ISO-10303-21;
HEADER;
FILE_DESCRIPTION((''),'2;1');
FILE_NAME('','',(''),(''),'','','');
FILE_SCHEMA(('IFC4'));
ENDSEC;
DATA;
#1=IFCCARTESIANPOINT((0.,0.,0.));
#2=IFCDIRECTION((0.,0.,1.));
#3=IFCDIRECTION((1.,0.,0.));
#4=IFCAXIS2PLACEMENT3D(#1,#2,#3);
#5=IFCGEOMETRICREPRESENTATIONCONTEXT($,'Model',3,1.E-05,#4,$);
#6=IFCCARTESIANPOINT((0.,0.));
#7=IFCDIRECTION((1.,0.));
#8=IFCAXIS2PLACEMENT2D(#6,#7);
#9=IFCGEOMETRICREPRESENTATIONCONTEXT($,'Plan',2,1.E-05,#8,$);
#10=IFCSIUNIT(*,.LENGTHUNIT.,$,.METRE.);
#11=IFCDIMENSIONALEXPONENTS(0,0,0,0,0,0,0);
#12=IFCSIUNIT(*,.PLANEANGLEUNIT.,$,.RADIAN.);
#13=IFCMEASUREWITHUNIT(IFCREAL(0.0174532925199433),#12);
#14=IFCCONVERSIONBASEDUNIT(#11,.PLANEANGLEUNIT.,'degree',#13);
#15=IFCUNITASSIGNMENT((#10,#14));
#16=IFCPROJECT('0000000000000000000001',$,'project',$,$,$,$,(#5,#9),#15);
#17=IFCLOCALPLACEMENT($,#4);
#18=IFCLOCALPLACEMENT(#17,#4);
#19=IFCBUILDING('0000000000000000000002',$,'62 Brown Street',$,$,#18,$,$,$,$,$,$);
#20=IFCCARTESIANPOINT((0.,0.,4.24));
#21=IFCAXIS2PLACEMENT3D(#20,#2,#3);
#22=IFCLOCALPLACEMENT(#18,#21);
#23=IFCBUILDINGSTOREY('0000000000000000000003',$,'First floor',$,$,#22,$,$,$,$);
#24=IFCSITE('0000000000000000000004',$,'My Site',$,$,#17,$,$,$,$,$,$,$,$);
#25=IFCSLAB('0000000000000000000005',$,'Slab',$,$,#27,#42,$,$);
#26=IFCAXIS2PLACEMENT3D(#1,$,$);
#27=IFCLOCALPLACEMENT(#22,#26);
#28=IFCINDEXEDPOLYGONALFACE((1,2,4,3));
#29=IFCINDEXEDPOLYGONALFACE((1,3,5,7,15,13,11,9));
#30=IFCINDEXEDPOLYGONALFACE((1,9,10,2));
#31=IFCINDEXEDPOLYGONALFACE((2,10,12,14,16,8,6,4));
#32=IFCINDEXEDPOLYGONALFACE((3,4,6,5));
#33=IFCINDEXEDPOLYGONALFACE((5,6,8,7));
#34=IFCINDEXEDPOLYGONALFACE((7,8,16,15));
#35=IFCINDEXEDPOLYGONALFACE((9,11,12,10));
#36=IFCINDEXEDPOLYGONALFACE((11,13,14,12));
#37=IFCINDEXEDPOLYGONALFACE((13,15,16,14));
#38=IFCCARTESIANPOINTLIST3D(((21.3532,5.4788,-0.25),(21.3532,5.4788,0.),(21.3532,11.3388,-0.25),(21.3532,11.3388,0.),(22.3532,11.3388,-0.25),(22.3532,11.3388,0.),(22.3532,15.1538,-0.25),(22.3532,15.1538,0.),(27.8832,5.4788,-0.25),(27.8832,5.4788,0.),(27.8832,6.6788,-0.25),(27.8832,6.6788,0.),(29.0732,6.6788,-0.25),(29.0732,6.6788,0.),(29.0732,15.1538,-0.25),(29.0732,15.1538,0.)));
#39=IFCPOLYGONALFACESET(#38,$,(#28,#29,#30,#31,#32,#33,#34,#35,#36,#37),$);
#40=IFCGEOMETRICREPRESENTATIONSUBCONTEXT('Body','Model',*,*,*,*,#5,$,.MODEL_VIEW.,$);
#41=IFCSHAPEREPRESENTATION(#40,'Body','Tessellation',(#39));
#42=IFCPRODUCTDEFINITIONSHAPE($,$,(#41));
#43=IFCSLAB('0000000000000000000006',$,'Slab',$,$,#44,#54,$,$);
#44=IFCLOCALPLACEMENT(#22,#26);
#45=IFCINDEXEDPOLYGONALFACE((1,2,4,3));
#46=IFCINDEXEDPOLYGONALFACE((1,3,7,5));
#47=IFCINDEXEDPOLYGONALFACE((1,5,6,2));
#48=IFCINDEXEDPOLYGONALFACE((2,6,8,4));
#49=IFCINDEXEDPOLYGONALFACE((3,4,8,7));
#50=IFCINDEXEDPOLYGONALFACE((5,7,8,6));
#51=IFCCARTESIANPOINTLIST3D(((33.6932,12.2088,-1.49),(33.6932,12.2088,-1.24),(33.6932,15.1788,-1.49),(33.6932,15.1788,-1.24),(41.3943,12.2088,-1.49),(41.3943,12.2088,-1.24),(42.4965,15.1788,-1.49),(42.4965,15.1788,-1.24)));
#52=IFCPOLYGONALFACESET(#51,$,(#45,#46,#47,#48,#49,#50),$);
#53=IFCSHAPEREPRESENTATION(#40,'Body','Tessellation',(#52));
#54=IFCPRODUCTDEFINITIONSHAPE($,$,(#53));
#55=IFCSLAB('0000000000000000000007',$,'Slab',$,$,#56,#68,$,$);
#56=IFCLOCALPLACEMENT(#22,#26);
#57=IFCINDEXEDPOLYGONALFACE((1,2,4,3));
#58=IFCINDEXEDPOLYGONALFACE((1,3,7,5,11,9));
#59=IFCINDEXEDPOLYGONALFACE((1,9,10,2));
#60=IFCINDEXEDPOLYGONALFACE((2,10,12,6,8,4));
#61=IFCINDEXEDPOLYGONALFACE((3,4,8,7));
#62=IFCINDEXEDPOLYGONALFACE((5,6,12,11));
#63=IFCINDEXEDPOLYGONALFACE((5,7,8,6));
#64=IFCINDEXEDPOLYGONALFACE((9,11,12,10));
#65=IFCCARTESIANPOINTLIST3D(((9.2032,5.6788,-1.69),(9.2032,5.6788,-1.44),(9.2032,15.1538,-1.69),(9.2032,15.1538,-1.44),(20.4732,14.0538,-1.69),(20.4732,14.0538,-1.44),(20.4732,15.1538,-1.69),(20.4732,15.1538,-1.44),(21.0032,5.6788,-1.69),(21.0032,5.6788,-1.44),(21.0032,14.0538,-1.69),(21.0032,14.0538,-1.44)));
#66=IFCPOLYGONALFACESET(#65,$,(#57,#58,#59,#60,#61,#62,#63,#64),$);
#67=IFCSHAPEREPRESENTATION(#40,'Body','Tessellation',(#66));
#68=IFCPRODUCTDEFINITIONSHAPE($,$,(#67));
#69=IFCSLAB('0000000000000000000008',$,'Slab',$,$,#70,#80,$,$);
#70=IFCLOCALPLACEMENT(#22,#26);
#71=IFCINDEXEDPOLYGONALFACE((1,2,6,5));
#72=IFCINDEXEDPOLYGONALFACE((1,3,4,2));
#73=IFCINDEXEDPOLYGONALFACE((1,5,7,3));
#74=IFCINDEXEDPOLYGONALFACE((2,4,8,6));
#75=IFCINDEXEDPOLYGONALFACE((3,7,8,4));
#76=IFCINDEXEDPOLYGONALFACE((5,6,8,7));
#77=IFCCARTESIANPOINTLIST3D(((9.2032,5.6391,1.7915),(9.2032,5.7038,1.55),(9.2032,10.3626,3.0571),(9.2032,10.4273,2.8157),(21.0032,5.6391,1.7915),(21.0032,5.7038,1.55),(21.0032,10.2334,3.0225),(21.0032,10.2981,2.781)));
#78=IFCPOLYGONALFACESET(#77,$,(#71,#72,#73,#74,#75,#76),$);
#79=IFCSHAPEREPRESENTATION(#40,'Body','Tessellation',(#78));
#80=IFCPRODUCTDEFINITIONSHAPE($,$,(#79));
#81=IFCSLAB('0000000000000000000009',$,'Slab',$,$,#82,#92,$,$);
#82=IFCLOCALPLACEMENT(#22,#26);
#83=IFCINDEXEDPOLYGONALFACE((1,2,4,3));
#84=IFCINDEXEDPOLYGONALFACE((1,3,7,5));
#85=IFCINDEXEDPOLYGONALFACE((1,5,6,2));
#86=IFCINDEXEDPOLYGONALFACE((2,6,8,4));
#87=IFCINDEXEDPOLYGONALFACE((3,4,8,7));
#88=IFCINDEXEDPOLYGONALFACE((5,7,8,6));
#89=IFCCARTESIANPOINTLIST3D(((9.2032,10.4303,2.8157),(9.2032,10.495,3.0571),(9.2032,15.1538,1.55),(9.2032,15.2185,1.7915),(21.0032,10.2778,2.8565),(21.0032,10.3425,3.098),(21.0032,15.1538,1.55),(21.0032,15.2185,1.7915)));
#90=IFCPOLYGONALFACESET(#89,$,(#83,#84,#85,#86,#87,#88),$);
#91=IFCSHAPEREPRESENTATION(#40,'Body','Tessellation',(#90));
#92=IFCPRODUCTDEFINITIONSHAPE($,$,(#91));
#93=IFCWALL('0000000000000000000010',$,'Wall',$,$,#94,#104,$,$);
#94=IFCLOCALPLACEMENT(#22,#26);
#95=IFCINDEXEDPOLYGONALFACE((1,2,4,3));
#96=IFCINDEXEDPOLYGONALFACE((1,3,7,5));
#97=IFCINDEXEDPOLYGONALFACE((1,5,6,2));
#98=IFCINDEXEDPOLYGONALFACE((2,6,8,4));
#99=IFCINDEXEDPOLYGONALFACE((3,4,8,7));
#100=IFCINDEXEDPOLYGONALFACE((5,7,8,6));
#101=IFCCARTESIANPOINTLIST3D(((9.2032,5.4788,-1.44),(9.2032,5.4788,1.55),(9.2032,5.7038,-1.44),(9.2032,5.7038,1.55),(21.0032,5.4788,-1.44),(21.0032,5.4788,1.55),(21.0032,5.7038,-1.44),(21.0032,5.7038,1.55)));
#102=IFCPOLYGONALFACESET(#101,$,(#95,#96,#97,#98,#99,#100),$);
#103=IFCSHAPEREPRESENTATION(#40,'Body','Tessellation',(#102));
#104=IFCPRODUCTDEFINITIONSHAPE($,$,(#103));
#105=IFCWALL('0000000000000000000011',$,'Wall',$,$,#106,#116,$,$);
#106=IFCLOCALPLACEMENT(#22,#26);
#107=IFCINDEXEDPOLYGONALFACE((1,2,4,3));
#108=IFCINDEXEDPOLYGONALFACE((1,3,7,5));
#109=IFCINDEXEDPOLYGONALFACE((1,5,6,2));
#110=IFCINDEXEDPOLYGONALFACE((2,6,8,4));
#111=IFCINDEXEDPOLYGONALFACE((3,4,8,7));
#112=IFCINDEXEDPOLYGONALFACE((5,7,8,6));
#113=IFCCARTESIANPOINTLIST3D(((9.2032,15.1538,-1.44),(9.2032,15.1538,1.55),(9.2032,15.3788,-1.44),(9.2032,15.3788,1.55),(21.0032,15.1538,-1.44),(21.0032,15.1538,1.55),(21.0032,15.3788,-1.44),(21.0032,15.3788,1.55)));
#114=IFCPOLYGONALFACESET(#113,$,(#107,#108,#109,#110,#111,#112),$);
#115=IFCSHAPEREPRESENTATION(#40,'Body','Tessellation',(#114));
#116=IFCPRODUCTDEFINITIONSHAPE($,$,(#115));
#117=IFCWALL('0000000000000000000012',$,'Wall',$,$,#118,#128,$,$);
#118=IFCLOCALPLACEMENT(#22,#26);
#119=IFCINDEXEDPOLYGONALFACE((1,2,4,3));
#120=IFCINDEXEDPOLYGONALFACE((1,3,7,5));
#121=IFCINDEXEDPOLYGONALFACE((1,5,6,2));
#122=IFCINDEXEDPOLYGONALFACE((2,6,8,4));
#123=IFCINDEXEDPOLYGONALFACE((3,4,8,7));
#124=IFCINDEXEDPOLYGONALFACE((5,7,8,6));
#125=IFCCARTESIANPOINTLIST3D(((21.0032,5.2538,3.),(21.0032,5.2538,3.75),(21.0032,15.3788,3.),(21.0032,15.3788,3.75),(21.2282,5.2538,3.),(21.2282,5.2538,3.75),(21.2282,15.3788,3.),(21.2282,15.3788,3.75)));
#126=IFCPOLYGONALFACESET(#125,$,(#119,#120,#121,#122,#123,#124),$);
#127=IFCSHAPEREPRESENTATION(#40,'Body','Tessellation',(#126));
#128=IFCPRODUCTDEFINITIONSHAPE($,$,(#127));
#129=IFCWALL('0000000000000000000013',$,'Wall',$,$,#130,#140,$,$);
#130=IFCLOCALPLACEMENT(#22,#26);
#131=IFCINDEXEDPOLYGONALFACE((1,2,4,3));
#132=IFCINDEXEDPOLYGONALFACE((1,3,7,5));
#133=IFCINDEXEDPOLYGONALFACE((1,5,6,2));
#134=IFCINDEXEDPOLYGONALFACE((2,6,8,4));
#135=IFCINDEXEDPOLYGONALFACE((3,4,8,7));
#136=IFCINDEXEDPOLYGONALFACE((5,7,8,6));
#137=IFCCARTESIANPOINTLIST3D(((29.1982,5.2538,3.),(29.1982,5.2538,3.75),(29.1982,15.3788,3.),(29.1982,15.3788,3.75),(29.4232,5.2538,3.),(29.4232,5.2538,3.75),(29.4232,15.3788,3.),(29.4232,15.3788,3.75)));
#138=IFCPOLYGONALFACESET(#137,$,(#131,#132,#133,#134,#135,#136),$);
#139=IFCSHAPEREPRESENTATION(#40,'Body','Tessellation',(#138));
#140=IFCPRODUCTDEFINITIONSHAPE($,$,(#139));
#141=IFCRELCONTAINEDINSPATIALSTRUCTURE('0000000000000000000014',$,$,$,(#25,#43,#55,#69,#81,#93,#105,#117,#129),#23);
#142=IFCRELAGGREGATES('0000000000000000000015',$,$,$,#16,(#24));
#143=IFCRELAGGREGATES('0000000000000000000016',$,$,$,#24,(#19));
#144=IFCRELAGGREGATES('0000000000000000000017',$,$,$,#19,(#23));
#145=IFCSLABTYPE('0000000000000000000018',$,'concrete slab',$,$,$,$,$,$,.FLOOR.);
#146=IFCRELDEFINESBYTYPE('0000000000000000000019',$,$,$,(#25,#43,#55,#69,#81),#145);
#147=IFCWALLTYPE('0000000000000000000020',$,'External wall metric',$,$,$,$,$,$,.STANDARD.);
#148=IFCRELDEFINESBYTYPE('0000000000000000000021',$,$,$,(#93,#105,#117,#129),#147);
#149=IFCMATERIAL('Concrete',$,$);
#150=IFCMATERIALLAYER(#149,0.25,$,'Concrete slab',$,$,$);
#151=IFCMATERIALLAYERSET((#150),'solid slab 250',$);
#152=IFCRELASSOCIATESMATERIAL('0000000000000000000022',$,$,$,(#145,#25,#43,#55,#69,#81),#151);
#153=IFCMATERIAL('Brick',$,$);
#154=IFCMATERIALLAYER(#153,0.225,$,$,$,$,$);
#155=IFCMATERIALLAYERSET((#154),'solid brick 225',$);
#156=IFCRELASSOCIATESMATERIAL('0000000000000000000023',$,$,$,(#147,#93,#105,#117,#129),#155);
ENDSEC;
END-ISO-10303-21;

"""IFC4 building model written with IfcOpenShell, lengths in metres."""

from ifc_helpers import new_model, entity, si_unit, converted_unit, frame, origin_with_axes, origin_2d_with_axis, place, context, subcontext, project, spatial, line, indexed_curve, outline, extrude, material, layer, layer_set, layer_usage, type_object, element, save


model = new_model("IFC4")

# Units and contexts
model_context = context("Model", 3, precision=1e-05, world=origin_with_axes())
plan_context = context("Plan", 2, precision=1e-05, world=origin_2d_with_axis())
body_context_1 = subcontext(model_context, "Body", "Model", "MODEL_VIEW")
ifc_project = project(units=[si_unit("LENGTHUNIT", "METRE"), converted_unit("PLANEANGLEUNIT", "degree", entity("IfcReal", 0.0174532925199433), si_unit("PLANEANGLEUNIT", "RADIAN"), dimensions=[0, 0, 0, 0, 0, 0, 0])], contexts=[model_context, plan_context])

# Site, building, storey
site_placement = place(None, origin_with_axes())
site = spatial("IfcSite", under=ifc_project, at=site_placement, Name="My Site")
building_placement = place(site_placement, origin_with_axes())
building = spatial("IfcBuilding", under=site, at=building_placement, Name="62 Brown Street")
storey_placement = place(building_placement, frame((0.0, 0.0, 4.24), z_axis=(0.0, 0.0, 1.0), x_axis=(1.0, 0.0, 0.0)))
storey = spatial("IfcBuildingStorey", under=building, at=storey_placement, Name="First floor")

# Slabs
ifc_material_1 = material(Name="Concrete")
ifc_layer_1 = layer(ifc_material_1, 0.25, Name="Concrete slab")
ifc_layer_set_1 = layer_set([ifc_layer_1], Name="solid slab 250")
ifc_layer_usage_1 = layer_usage(ifc_layer_set_1, "AXIS3", "POSITIVE", 0.0)
slab_type = type_object("IfcSlabType", Name="concrete slab", PredefinedType="FLOOR", material=ifc_layer_set_1)
slab_1_placement = place(storey_placement, frame((21.3532, 5.4788, -0.25), z_axis=(0.0, 0.0, 1.0), x_axis=(1.0, 0.0, 0.0)))
element("IfcSlab", 1, at=slab_1_placement, inside=storey, type_object=slab_type, material=ifc_layer_usage_1, Name="Slab", context=body_context_1, shape_type="SweptSolid", body=[
    extrude(outline(indexed_curve([(0.0, 5.86), (0.0, 0.0), (6.53, 0.0), (6.53, 1.2), (7.72, 1.2), (7.72, 9.675), (1.0, 9.675), (1.0, 5.86)], segments=[line(3, 2), line(2, 1), line(1, 8), line(8, 7), line(7, 6), line(6, 5), line(5, 4), line(4, 3)], self_intersect=False)), None, (0.0, 0.0, 1.0), 0.25),
])
ifc_layer_usage_2 = layer_usage(ifc_layer_set_1, "AXIS3", "POSITIVE", 0.0)
slab_2_placement = place(storey_placement, frame((33.6932, 12.2088, -1.49), z_axis=(0.0, 0.0, 1.0), x_axis=(1.0, 0.0, 0.0)))
element("IfcSlab", 2, at=slab_2_placement, inside=storey, type_object=slab_type, material=ifc_layer_usage_2, Name="Slab", context=body_context_1, shape_type="SweptSolid", body=[
    extrude(outline(indexed_curve([(8.8033, 2.97), (7.7011, 0.0), (0.0, 0.0), (0.0, 2.97)], segments=[line(4, 1), line(1, 2), line(2, 3), line(3, 4)], self_intersect=False)), None, (0.0, 0.0, 1.0), 0.25),
])
ifc_layer_usage_3 = layer_usage(ifc_layer_set_1, "AXIS3", "POSITIVE", 0.0)
slab_3_placement = place(storey_placement, frame((9.2032, 5.6788, -1.69), z_axis=(0.0, 0.0, 1.0), x_axis=(1.0, 0.0, 0.0)))
element("IfcSlab", 3, at=slab_3_placement, inside=storey, type_object=slab_type, material=ifc_layer_usage_3, Name="Slab", context=body_context_1, shape_type="SweptSolid", body=[
    extrude(outline(indexed_curve([(11.27, 9.475), (11.8, 0.0), (0.0, 0.0), (0.0, 9.475), (11.8, 8.375), (11.27, 8.375)], segments=[line(6, 1), line(1, 4), line(4, 3), line(3, 2), line(2, 5), line(5, 6)], self_intersect=False)), None, (0.0, 0.0, 1.0), 0.25),
])
ifc_layer_usage_4 = layer_usage(ifc_layer_set_1, "AXIS3", "POSITIVE", 0.0)
slab_4_placement = place(storey_placement, frame((9.2032, 5.7038, 1.55), z_axis=(0.0, -0.258819, 0.965926), x_axis=(1.0, 0.0, 0.0)))
element("IfcSlab", 4, at=slab_4_placement, inside=storey, type_object=slab_type, material=ifc_layer_usage_4, Name="Slab", context=body_context_1, shape_type="SweptSolid", body=[
    extrude(outline(indexed_curve([(0.0, 4.8901), (0.0, 0.0), (11.8, 0.0), (11.8, 4.7563)], segments=[line(3, 2), line(2, 1), line(1, 4), line(4, 3)], self_intersect=False)), None, (0.0, 0.0, 1.0), 0.25),
])
ifc_layer_usage_5 = layer_usage(ifc_layer_set_1, "AXIS3", "POSITIVE", 0.0)
slab_5_placement = place(storey_placement, frame((21.0032, 15.1538, 1.55), z_axis=(0.0, 0.258819, 0.965926), x_axis=(-1.0, 0.0, 0.0)))
element("IfcSlab", 5, at=slab_5_placement, inside=storey, type_object=slab_type, material=ifc_layer_usage_5, Name="Slab", context=body_context_1, shape_type="SweptSolid", body=[
    extrude(outline(indexed_curve([(0.0, 0.0), (11.8, 0.0), (11.8, 4.8901), (0.0, 5.048)], segments=[line(4, 1), line(1, 2), line(2, 3), line(3, 4)], self_intersect=False)), None, (0.0, 0.0, 1.0), 0.25),
])

# Walls
ifc_material_2 = material(Name="Brick")
ifc_layer_2 = layer(ifc_material_2, 0.225)
ifc_layer_set_2 = layer_set([ifc_layer_2], Name="solid brick 225")
ifc_layer_usage_6 = layer_usage(ifc_layer_set_2, "AXIS2", "POSITIVE", 0.0)
wall_type_1 = type_object("IfcWallType", Name="External wall metric", PredefinedType="STANDARD", material=ifc_layer_set_2)
wall_1_placement = place(storey_placement, frame((9.2032, 5.4788, -1.44), z_axis=(0.0, 0.0, 1.0), x_axis=(1.0, 0.0, 0.0)))
element("IfcWall", 6, at=wall_1_placement, inside=storey, type_object=wall_type_1, material=ifc_layer_usage_6, Name="Wall", context=body_context_1, shape_type="SweptSolid", body=[
    extrude(outline(indexed_curve([(0.0, 0.0), (0.0, 0.225), (11.8, 0.225), (11.8, 0.0), (0.0, 0.0)], self_intersect=False)), origin_with_axes(), (0.0, 0.0, 1.0), 2.99),
])
ifc_layer_usage_7 = layer_usage(ifc_layer_set_2, "AXIS2", "POSITIVE", 0.0)
wall_2_placement = place(storey_placement, frame((21.0032, 15.3788, -1.44), z_axis=(0.0, 0.0, 1.0), x_axis=(-1.0, 0.0, 0.0)))
element("IfcWall", 7, at=wall_2_placement, inside=storey, type_object=wall_type_1, material=ifc_layer_usage_7, Name="Wall", context=body_context_1, shape_type="SweptSolid", body=[
    extrude(outline(indexed_curve([(0.0, 0.0), (0.0, 0.225), (11.8, 0.225), (11.8, 0.0), (0.0, 0.0)], self_intersect=False)), origin_with_axes(), (0.0, 0.0, 1.0), 2.99),
])
ifc_layer_usage_8 = layer_usage(ifc_layer_set_2, "AXIS2", "POSITIVE", 0.0)
wall_3_placement = place(storey_placement, frame((21.0032, 15.3788, 3.0), z_axis=(0.0, 0.0, 1.0), x_axis=(0.0, -1.0, 0.0)))
element("IfcWall", 8, at=wall_3_placement, inside=storey, type_object=wall_type_1, material=ifc_layer_usage_8, Name="Wall", context=body_context_1, shape_type="SweptSolid", body=[
    extrude(outline(indexed_curve([(0.0, 0.0), (0.0, 0.225), (10.125, 0.225), (10.125, 0.0), (0.0, 0.0)], self_intersect=False)), origin_with_axes(), (0.0, 0.0, 1.0), 0.75),
])
ifc_layer_usage_9 = layer_usage(ifc_layer_set_2, "AXIS2", "POSITIVE", 0.0)
wall_4_placement = place(storey_placement, frame((29.4232, 5.2538, 3.0), z_axis=(0.0, 0.0, 1.0), x_axis=(0.0, 1.0, 0.0)))
element("IfcWall", 9, at=wall_4_placement, inside=storey, type_object=wall_type_1, material=ifc_layer_usage_9, Name="Wall", context=body_context_1, shape_type="SweptSolid", body=[
    extrude(outline(indexed_curve([(0.0, 0.0), (0.0, 0.225), (10.125, 0.225), (10.125, 0.0), (0.0, 0.0)], self_intersect=False)), origin_with_axes(), (0.0, 0.0, 1.0), 0.75),
])

save(model, "model.ifc")
